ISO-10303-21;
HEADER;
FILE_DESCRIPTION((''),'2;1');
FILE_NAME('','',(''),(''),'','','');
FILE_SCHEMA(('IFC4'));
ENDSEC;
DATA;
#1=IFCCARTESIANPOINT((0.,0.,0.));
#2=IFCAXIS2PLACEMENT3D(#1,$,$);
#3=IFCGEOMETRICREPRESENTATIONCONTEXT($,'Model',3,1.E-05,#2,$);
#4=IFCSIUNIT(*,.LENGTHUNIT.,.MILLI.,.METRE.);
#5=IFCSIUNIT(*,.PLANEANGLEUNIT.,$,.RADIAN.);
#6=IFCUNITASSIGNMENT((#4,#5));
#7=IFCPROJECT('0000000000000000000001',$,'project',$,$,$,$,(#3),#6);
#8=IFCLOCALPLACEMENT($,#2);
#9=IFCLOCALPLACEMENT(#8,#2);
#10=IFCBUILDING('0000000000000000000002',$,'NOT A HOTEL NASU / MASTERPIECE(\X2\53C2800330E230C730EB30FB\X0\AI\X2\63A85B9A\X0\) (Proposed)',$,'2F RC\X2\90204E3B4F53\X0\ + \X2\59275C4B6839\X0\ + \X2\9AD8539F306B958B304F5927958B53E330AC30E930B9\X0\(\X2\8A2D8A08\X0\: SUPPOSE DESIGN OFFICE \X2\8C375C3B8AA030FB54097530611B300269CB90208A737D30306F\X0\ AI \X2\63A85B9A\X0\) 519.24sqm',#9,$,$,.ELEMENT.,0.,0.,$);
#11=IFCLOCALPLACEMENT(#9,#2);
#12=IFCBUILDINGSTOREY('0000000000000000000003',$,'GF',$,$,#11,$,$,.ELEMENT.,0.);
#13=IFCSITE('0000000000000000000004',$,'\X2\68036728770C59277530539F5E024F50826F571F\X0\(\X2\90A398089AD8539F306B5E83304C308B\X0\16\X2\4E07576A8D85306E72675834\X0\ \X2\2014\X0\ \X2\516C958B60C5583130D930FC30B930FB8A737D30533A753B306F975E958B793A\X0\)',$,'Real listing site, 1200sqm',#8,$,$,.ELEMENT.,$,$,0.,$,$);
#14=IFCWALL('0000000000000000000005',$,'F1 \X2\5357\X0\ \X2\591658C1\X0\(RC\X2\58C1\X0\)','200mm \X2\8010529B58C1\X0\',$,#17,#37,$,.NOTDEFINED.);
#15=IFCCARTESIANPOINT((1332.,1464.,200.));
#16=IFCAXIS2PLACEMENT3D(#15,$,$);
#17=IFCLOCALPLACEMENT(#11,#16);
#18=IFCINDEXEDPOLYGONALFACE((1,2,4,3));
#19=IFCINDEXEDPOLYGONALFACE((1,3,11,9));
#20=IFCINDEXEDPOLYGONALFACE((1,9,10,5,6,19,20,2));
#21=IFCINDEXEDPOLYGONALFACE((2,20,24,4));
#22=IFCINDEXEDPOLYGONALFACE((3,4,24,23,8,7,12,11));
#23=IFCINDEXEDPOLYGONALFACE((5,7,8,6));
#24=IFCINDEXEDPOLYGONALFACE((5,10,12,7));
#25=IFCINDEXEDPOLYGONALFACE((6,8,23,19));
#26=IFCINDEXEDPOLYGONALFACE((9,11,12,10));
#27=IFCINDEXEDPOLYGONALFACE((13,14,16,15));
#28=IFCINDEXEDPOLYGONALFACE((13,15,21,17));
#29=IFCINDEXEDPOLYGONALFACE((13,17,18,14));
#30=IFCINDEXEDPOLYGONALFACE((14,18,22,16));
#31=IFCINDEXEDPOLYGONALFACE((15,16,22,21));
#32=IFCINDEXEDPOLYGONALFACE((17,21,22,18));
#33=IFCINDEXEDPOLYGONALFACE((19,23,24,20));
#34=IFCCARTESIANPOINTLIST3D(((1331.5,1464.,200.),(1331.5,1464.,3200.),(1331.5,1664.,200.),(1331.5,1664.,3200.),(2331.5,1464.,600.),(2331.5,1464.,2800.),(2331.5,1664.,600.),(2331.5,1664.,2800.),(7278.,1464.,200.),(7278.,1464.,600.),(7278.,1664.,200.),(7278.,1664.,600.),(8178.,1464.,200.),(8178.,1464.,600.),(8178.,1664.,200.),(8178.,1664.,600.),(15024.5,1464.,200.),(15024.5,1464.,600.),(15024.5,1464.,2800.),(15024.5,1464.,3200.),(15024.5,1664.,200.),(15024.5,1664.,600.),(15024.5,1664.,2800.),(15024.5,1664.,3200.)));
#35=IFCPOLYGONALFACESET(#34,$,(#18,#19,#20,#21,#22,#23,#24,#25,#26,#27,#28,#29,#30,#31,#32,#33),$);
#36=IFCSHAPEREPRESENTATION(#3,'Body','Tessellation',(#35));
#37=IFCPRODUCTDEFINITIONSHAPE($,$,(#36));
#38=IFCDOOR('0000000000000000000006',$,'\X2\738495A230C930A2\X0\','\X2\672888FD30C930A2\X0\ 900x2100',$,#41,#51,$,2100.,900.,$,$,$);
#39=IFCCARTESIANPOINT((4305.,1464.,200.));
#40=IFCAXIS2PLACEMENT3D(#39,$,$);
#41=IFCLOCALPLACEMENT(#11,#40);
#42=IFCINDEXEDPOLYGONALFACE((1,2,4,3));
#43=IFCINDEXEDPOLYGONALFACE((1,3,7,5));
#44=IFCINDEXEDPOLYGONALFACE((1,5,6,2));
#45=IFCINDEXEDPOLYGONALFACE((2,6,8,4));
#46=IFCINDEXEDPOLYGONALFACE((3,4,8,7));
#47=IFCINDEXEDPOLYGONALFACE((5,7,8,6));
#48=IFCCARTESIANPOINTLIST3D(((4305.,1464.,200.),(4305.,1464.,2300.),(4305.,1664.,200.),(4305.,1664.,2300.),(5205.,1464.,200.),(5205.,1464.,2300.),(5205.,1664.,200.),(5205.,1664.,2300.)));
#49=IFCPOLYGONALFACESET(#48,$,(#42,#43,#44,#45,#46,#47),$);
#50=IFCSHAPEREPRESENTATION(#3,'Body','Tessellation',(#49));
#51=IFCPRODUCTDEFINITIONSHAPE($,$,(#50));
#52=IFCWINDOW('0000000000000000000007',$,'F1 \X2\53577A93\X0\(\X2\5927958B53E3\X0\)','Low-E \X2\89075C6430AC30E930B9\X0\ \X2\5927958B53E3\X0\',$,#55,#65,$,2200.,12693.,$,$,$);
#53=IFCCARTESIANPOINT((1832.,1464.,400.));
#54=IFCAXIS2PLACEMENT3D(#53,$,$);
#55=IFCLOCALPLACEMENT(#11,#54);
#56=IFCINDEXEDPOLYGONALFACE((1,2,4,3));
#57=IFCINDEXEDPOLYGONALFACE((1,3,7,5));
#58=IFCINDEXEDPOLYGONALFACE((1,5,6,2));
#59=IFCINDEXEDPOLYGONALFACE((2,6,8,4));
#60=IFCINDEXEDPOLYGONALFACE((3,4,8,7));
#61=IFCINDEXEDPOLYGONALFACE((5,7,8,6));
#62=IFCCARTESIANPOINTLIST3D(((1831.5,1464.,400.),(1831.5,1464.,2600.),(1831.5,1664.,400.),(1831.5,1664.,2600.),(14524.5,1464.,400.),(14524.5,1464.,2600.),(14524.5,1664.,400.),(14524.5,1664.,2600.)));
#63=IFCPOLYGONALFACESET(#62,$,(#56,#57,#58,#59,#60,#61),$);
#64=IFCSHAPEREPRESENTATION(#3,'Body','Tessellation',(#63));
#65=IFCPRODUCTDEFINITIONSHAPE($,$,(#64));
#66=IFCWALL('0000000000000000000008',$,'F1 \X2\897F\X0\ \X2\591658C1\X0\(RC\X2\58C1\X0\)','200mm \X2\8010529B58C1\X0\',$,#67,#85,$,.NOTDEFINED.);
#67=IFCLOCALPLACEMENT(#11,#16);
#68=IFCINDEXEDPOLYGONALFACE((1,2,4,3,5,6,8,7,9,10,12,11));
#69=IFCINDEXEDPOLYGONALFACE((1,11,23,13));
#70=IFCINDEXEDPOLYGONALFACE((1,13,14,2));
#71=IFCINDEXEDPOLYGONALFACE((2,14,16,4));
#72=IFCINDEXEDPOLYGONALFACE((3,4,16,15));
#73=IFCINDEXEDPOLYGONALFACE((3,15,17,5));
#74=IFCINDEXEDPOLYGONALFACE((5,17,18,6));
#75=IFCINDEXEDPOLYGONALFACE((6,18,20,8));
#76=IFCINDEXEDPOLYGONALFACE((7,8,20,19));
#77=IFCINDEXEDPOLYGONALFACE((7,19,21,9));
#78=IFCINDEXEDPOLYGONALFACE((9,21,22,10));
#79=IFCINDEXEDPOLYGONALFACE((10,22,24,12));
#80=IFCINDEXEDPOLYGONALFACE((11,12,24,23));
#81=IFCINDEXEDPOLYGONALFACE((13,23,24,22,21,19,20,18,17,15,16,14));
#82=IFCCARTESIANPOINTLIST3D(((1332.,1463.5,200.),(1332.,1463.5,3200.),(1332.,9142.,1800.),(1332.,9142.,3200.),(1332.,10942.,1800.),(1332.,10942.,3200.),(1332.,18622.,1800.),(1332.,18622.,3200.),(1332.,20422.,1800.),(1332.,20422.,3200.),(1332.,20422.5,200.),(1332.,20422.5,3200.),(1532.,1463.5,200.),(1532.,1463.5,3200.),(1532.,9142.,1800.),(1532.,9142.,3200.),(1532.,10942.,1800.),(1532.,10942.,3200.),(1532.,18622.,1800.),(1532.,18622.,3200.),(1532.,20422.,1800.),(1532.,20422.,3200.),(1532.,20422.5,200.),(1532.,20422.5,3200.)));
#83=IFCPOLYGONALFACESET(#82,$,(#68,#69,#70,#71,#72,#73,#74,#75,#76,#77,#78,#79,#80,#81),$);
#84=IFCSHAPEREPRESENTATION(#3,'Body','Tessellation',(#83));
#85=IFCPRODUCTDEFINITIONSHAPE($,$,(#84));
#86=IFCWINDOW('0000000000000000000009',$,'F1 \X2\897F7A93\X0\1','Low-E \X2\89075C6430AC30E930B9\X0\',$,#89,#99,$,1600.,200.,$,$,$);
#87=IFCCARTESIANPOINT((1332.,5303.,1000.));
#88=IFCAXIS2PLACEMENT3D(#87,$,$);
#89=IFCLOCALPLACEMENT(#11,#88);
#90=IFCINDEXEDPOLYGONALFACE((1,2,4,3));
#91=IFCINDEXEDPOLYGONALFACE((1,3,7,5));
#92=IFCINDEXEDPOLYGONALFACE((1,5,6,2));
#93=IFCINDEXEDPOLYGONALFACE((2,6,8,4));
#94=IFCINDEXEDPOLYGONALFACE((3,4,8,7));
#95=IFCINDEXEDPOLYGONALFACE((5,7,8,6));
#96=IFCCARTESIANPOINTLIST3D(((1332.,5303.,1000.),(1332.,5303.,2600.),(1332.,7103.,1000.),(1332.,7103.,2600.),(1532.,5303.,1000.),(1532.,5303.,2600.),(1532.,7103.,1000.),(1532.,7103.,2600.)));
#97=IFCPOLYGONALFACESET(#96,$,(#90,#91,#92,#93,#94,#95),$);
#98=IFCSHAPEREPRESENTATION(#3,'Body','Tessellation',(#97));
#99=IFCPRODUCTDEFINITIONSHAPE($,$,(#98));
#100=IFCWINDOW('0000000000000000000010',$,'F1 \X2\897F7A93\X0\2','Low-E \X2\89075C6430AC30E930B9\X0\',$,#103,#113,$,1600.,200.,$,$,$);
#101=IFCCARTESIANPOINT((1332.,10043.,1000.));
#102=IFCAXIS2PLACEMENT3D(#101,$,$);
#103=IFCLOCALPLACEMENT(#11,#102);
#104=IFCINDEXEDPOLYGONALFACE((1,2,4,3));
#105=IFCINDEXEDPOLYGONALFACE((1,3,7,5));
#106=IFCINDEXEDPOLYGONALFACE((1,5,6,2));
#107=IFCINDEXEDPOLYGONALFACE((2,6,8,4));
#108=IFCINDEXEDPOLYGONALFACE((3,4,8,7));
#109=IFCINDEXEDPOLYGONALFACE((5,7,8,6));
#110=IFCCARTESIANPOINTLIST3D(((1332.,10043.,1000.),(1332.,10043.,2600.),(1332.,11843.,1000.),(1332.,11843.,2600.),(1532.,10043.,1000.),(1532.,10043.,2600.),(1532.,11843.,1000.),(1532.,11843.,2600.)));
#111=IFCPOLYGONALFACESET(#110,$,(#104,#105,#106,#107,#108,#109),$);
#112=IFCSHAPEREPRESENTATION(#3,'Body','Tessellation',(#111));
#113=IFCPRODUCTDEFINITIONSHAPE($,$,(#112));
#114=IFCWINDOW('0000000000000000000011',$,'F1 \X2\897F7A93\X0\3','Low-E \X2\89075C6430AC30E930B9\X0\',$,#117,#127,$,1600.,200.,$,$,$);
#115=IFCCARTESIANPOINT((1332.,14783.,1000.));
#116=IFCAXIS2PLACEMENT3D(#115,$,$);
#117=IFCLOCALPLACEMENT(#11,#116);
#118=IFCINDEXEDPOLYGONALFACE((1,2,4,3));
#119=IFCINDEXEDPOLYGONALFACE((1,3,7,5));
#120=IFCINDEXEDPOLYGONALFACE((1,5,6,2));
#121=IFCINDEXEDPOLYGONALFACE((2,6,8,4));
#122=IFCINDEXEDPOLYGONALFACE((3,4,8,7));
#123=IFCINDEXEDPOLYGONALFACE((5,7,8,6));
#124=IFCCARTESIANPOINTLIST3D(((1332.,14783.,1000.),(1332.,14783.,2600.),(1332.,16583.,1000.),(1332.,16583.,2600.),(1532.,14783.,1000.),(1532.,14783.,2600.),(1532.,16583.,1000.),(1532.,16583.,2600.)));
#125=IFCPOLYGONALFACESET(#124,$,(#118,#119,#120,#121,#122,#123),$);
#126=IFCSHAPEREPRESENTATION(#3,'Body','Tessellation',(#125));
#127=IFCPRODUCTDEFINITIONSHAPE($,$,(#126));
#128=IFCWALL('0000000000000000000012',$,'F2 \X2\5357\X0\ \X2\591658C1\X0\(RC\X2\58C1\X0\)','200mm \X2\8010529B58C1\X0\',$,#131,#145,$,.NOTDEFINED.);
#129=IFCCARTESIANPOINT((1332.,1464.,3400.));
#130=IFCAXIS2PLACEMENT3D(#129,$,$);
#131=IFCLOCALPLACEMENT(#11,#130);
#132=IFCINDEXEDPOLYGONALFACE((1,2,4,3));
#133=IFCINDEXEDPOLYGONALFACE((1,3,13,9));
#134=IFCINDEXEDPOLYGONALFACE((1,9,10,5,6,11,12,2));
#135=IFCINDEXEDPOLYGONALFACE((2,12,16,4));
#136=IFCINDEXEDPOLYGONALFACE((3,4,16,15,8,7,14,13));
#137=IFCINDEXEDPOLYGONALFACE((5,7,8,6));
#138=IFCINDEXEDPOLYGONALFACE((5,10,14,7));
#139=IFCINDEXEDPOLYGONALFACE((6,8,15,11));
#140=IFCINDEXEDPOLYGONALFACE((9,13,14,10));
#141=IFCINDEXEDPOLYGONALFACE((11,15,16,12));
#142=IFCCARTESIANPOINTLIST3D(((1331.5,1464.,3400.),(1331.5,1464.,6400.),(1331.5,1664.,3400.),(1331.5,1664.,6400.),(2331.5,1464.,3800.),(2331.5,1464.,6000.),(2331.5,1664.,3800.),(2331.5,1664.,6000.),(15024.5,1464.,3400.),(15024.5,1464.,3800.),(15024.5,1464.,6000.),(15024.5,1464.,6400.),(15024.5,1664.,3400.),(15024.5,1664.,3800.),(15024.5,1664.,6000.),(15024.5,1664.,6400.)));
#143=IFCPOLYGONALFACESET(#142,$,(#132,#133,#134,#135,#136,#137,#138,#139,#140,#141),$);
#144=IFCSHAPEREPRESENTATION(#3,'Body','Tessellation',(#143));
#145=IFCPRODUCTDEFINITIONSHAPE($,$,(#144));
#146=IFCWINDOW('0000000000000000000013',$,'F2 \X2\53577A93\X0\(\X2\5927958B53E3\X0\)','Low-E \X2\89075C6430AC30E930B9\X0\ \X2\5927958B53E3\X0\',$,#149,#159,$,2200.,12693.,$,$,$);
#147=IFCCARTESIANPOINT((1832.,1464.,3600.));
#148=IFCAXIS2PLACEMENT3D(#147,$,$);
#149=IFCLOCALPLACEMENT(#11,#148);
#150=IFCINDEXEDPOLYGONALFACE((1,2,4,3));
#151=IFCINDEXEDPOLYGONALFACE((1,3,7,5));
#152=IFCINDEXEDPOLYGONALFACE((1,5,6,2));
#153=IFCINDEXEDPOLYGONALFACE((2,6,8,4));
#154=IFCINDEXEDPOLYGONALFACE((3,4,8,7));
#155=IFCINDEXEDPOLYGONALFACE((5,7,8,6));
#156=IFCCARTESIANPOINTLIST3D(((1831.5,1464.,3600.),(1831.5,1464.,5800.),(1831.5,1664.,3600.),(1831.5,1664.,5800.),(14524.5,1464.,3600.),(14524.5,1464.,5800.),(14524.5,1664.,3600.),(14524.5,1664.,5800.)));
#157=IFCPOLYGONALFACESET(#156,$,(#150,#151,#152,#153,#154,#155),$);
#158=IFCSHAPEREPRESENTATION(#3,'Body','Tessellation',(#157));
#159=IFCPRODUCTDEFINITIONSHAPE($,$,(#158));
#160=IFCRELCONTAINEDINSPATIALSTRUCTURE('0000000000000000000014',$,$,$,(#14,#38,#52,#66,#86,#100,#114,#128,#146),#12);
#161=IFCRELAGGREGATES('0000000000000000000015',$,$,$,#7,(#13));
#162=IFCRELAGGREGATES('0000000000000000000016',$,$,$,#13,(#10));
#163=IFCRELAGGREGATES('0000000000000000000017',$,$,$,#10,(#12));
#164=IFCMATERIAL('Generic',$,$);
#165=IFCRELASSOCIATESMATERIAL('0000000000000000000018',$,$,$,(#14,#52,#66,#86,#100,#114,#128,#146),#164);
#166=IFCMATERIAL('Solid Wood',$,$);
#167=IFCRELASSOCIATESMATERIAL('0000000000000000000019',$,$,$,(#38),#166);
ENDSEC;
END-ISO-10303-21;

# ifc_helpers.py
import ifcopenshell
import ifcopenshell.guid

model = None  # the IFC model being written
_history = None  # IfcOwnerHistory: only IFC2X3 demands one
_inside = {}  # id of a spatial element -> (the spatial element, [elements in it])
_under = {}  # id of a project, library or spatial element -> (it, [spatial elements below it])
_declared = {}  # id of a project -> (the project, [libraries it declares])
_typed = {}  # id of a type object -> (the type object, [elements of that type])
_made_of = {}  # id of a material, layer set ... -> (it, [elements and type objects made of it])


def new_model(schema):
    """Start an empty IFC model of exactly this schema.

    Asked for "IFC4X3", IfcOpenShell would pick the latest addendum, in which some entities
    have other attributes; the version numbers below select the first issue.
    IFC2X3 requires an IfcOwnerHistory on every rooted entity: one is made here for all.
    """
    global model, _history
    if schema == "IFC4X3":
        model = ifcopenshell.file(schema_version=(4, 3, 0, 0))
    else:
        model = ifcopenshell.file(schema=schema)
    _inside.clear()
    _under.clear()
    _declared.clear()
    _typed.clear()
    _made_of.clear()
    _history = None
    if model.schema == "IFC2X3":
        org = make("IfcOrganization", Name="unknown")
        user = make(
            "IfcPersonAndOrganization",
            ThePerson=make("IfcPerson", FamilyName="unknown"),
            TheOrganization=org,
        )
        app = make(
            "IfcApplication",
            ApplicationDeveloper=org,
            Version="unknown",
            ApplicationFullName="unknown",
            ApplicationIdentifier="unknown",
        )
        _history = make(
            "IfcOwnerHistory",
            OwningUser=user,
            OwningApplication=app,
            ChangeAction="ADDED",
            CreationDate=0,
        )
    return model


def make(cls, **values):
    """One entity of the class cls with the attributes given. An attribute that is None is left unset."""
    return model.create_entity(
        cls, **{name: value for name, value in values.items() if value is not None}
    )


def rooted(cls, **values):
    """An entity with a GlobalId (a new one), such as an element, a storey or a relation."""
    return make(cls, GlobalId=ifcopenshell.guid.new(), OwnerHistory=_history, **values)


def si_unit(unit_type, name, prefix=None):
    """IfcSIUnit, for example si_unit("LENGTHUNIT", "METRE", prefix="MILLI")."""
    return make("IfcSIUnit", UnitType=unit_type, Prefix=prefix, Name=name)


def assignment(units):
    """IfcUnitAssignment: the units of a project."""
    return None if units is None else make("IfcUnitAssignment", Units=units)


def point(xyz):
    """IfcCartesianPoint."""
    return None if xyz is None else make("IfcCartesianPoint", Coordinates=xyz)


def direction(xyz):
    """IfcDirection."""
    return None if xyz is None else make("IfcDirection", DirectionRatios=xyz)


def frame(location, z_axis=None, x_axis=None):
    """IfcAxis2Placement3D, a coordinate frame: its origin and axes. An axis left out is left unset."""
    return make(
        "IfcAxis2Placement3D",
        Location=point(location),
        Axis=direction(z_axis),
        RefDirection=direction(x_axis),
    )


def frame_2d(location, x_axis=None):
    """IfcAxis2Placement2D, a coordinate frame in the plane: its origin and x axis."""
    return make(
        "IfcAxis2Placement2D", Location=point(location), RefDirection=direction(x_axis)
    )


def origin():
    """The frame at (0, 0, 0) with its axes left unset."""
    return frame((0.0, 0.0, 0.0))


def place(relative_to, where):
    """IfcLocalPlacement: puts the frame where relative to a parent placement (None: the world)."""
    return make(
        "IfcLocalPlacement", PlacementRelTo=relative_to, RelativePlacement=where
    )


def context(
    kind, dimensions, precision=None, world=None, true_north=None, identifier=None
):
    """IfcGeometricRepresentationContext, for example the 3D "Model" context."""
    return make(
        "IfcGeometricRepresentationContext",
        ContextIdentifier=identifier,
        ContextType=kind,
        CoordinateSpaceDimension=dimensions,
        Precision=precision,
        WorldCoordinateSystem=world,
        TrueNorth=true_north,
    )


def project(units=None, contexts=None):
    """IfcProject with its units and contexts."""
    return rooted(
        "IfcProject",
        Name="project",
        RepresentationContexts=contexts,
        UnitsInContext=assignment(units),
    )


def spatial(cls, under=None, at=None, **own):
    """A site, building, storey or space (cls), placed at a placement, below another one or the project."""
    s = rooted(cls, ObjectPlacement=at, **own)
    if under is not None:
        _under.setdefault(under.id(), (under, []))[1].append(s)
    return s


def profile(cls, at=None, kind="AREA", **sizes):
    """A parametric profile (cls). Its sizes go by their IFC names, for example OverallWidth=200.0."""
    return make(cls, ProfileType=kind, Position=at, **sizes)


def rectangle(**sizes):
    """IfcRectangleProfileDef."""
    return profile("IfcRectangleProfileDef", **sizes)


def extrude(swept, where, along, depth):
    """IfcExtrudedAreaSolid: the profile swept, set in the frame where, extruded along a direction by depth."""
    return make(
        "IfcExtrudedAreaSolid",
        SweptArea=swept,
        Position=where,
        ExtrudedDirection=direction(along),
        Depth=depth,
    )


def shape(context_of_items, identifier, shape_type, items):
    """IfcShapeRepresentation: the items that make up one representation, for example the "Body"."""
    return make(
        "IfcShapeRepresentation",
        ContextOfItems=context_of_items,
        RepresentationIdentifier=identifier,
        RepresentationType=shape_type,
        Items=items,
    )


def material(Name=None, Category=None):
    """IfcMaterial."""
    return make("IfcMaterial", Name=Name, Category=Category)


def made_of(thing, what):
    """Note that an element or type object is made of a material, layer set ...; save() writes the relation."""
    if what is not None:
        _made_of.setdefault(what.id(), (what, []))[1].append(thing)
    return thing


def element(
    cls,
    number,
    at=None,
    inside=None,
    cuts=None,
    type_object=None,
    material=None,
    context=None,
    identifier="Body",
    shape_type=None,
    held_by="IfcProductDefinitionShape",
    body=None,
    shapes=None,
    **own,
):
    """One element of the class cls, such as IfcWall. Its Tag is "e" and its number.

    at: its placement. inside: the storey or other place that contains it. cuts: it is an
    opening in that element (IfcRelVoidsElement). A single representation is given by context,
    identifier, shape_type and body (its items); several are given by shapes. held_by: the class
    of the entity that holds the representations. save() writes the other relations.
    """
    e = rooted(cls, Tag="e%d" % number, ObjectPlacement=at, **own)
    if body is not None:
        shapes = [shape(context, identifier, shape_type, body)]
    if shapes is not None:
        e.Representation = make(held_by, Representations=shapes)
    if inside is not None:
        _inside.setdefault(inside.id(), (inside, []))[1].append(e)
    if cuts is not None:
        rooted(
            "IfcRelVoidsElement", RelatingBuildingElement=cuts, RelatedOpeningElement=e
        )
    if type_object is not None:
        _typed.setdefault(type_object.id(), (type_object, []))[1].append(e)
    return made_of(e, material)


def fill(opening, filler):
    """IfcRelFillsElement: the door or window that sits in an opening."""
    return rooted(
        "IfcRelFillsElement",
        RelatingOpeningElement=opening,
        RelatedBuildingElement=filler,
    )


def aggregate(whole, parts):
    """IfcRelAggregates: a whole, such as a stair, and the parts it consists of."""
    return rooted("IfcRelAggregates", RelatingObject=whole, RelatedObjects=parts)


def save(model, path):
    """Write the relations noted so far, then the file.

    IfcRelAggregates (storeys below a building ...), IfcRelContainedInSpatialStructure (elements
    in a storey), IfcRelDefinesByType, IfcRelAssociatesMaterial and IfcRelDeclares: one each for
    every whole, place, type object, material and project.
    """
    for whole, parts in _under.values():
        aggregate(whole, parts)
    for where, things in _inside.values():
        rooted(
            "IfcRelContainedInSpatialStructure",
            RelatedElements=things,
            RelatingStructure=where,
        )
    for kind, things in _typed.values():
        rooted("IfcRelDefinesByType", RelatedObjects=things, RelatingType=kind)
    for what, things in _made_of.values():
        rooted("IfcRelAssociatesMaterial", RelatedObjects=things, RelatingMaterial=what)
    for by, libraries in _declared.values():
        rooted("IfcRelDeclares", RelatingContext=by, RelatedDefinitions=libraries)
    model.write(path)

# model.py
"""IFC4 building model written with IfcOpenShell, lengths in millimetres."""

from ifc_helpers import new_model, si_unit, frame, frame_2d, origin, place, context, project, spatial, rectangle, extrude, material, element, fill, save


model = new_model("IFC4")

# Units and contexts
model_context = context("Model", 3, precision=1e-05, world=origin())
ifc_project = project(units=[si_unit("LENGTHUNIT", "METRE", prefix="MILLI"), si_unit("PLANEANGLEUNIT", "RADIAN")], contexts=[model_context])

# Site, building, storey
site_placement = place(None, origin())
site = spatial("IfcSite", under=ifc_project, at=site_placement, Name="栃木県大田原市佐良土(那須高原に広がる16万坪超の牧場 — 公開情報ベース・詳細区画は非開示)", ObjectType="Real listing site, 1200sqm", CompositionType="ELEMENT", RefElevation=0.0)
building_placement = place(site_placement, origin())
building = spatial("IfcBuilding", under=site, at=building_placement, Name="NOT A HOTEL NASU / MASTERPIECE(参考モデル・AI推定) (Proposed)", ObjectType="2F RC造主体 + 大屋根 + 高原に開く大開口ガラス(設計: SUPPOSE DESIGN OFFICE 谷尻誠・吉田愛。構造詳細は AI 推定) 519.24sqm", CompositionType="ELEMENT", ElevationOfRefHeight=0.0, ElevationOfTerrain=0.0)
storey_placement = place(building_placement, origin())
storey = spatial("IfcBuildingStorey", under=building, at=storey_placement, Name="GF", CompositionType="ELEMENT", Elevation=0.0)

# Wall, openings, door, window
ifc_material_1 = material(Name="Generic")
wall_1_placement = place(storey_placement, frame((1332.0, 1464.0, 200.0)))
wall_1 = element("IfcWall", 1, at=wall_1_placement, inside=storey, material=ifc_material_1, Name="F1 南 外壁(RC壁)", Description="200mm 耐力壁", PredefinedType="NOTDEFINED", context=model_context, shape_type="SweptSolid", body=[
    extrude(rectangle(XDim=13693.0, YDim=200.0, at=frame_2d((6846.0, 100.0))), frame((1332.0, 1464.0, 200.0)), (0.0, 0.0, 1.0), 3000.0),
])
opening_1_placement = place(storey_placement, frame((4305.0, 1464.0, 200.0)))
opening_1 = element("IfcOpeningElement", 2, at=opening_1_placement, cuts=wall_1, PredefinedType="NOTDEFINED", context=model_context, shape_type="SweptSolid", body=[
    extrude(rectangle(XDim=900.0, YDim=200.0, at=frame_2d((450.0, 100.0))), frame((4305.0, 1464.0, 200.0)), (0.0, 0.0, 1.0), 2100.0),
])
opening_2_placement = place(storey_placement, frame((1832.0, 1464.0, 400.0)))
opening_2 = element("IfcOpeningElement", 3, at=opening_2_placement, cuts=wall_1, PredefinedType="NOTDEFINED", context=model_context, shape_type="SweptSolid", body=[
    extrude(rectangle(XDim=12693.0, YDim=200.0, at=frame_2d((6346.0, 100.0))), frame((1832.0, 1464.0, 400.0)), (0.0, 0.0, 1.0), 2200.0),
])
ifc_material_2 = material(Name="Solid Wood")
door_placement = place(storey_placement, frame((4305.0, 1464.0, 200.0)))
door = element("IfcDoor", 4, at=door_placement, inside=storey, material=ifc_material_2, Name="玄関ドア", Description="木製ドア 900x2100", OverallHeight=2100.0, OverallWidth=900.0, context=model_context, shape_type="SweptSolid", body=[
    extrude(rectangle(XDim=900.0, YDim=200.0, at=frame_2d((450.0, 100.0))), frame((4305.0, 1464.0, 200.0)), (0.0, 0.0, 1.0), 2100.0),
])
fill(opening_1, door)
window_1_placement = place(storey_placement, frame((1832.0, 1464.0, 400.0)))
window_1 = element("IfcWindow", 5, at=window_1_placement, inside=storey, material=ifc_material_1, Name="F1 南窓(大開口)", Description="Low-E 複層ガラス 大開口", OverallHeight=2200.0, OverallWidth=12693.0, context=model_context, shape_type="SweptSolid", body=[
    extrude(rectangle(XDim=12693.0, YDim=200.0, at=frame_2d((6346.0, 100.0))), frame((1832.0, 1464.0, 400.0)), (0.0, 0.0, 1.0), 2200.0),
])
fill(opening_2, window_1)

# Wall, openings, windows
wall_2_placement = place(storey_placement, frame((1332.0, 1464.0, 200.0)))
wall_2 = element("IfcWall", 6, at=wall_2_placement, inside=storey, material=ifc_material_1, Name="F1 西 外壁(RC壁)", Description="200mm 耐力壁", PredefinedType="NOTDEFINED", context=model_context, shape_type="SweptSolid", body=[
    extrude(rectangle(XDim=200.0, YDim=18959.0, at=frame_2d((100.0, 9479.0))), frame((1332.0, 1464.0, 200.0)), (0.0, 0.0, 1.0), 3000.0),
])
opening_3_placement = place(storey_placement, frame((1332.0, 5303.0, 1000.0)))
opening_3 = element("IfcOpeningElement", 7, at=opening_3_placement, cuts=wall_2, PredefinedType="NOTDEFINED", context=model_context, shape_type="SweptSolid", body=[
    extrude(rectangle(XDim=200.0, YDim=1800.0, at=frame_2d((100.0, 900.0))), frame((1332.0, 5303.0, 1000.0)), (0.0, 0.0, 1.0), 1600.0),
])
opening_4_placement = place(storey_placement, frame((1332.0, 10043.0, 1000.0)))
opening_4 = element("IfcOpeningElement", 8, at=opening_4_placement, cuts=wall_2, PredefinedType="NOTDEFINED", context=model_context, shape_type="SweptSolid", body=[
    extrude(rectangle(XDim=200.0, YDim=1800.0, at=frame_2d((100.0, 900.0))), frame((1332.0, 10043.0, 1000.0)), (0.0, 0.0, 1.0), 1600.0),
])
opening_5_placement = place(storey_placement, frame((1332.0, 14783.0, 1000.0)))
opening_5 = element("IfcOpeningElement", 9, at=opening_5_placement, cuts=wall_2, PredefinedType="NOTDEFINED", context=model_context, shape_type="SweptSolid", body=[
    extrude(rectangle(XDim=200.0, YDim=1800.0, at=frame_2d((100.0, 900.0))), frame((1332.0, 14783.0, 1000.0)), (0.0, 0.0, 1.0), 1600.0),
])
window_2_placement = place(storey_placement, frame((1332.0, 5303.0, 1000.0)))
window_2 = element("IfcWindow", 10, at=window_2_placement, inside=storey, material=ifc_material_1, Name="F1 西窓1", Description="Low-E 複層ガラス", OverallHeight=1600.0, OverallWidth=200.0, context=model_context, shape_type="SweptSolid", body=[
    extrude(rectangle(XDim=200.0, YDim=1800.0, at=frame_2d((100.0, 900.0))), frame((1332.0, 5303.0, 1000.0)), (0.0, 0.0, 1.0), 1600.0),
])
fill(opening_3, window_2)
window_3_placement = place(storey_placement, frame((1332.0, 10043.0, 1000.0)))
window_3 = element("IfcWindow", 11, at=window_3_placement, inside=storey, material=ifc_material_1, Name="F1 西窓2", Description="Low-E 複層ガラス", OverallHeight=1600.0, OverallWidth=200.0, context=model_context, shape_type="SweptSolid", body=[
    extrude(rectangle(XDim=200.0, YDim=1800.0, at=frame_2d((100.0, 900.0))), frame((1332.0, 10043.0, 1000.0)), (0.0, 0.0, 1.0), 1600.0),
])
fill(opening_4, window_3)
window_4_placement = place(storey_placement, frame((1332.0, 14783.0, 1000.0)))
window_4 = element("IfcWindow", 12, at=window_4_placement, inside=storey, material=ifc_material_1, Name="F1 西窓3", Description="Low-E 複層ガラス", OverallHeight=1600.0, OverallWidth=200.0, context=model_context, shape_type="SweptSolid", body=[
    extrude(rectangle(XDim=200.0, YDim=1800.0, at=frame_2d((100.0, 900.0))), frame((1332.0, 14783.0, 1000.0)), (0.0, 0.0, 1.0), 1600.0),
])
fill(opening_5, window_4)

# Wall, opening, window
wall_3_placement = place(storey_placement, frame((1332.0, 1464.0, 3400.0)))
wall_3 = element("IfcWall", 13, at=wall_3_placement, inside=storey, material=ifc_material_1, Name="F2 南 外壁(RC壁)", Description="200mm 耐力壁", PredefinedType="NOTDEFINED", context=model_context, shape_type="SweptSolid", body=[
    extrude(rectangle(XDim=13693.0, YDim=200.0, at=frame_2d((6846.0, 100.0))), frame((1332.0, 1464.0, 3400.0)), (0.0, 0.0, 1.0), 3000.0),
])
opening_6_placement = place(storey_placement, frame((1832.0, 1464.0, 3600.0)))
opening_6 = element("IfcOpeningElement", 14, at=opening_6_placement, cuts=wall_3, PredefinedType="NOTDEFINED", context=model_context, shape_type="SweptSolid", body=[
    extrude(rectangle(XDim=12693.0, YDim=200.0, at=frame_2d((6346.0, 100.0))), frame((1832.0, 1464.0, 3600.0)), (0.0, 0.0, 1.0), 2200.0),
])
window_5_placement = place(storey_placement, frame((1832.0, 1464.0, 3600.0)))
window_5 = element("IfcWindow", 15, at=window_5_placement, inside=storey, material=ifc_material_1, Name="F2 南窓(大開口)", Description="Low-E 複層ガラス 大開口", OverallHeight=2200.0, OverallWidth=12693.0, context=model_context, shape_type="SweptSolid", body=[
    extrude(rectangle(XDim=12693.0, YDim=200.0, at=frame_2d((6346.0, 100.0))), frame((1832.0, 1464.0, 3600.0)), (0.0, 0.0, 1.0), 2200.0),
])
fill(opening_6, window_5)

save(model, "model.ifc")
